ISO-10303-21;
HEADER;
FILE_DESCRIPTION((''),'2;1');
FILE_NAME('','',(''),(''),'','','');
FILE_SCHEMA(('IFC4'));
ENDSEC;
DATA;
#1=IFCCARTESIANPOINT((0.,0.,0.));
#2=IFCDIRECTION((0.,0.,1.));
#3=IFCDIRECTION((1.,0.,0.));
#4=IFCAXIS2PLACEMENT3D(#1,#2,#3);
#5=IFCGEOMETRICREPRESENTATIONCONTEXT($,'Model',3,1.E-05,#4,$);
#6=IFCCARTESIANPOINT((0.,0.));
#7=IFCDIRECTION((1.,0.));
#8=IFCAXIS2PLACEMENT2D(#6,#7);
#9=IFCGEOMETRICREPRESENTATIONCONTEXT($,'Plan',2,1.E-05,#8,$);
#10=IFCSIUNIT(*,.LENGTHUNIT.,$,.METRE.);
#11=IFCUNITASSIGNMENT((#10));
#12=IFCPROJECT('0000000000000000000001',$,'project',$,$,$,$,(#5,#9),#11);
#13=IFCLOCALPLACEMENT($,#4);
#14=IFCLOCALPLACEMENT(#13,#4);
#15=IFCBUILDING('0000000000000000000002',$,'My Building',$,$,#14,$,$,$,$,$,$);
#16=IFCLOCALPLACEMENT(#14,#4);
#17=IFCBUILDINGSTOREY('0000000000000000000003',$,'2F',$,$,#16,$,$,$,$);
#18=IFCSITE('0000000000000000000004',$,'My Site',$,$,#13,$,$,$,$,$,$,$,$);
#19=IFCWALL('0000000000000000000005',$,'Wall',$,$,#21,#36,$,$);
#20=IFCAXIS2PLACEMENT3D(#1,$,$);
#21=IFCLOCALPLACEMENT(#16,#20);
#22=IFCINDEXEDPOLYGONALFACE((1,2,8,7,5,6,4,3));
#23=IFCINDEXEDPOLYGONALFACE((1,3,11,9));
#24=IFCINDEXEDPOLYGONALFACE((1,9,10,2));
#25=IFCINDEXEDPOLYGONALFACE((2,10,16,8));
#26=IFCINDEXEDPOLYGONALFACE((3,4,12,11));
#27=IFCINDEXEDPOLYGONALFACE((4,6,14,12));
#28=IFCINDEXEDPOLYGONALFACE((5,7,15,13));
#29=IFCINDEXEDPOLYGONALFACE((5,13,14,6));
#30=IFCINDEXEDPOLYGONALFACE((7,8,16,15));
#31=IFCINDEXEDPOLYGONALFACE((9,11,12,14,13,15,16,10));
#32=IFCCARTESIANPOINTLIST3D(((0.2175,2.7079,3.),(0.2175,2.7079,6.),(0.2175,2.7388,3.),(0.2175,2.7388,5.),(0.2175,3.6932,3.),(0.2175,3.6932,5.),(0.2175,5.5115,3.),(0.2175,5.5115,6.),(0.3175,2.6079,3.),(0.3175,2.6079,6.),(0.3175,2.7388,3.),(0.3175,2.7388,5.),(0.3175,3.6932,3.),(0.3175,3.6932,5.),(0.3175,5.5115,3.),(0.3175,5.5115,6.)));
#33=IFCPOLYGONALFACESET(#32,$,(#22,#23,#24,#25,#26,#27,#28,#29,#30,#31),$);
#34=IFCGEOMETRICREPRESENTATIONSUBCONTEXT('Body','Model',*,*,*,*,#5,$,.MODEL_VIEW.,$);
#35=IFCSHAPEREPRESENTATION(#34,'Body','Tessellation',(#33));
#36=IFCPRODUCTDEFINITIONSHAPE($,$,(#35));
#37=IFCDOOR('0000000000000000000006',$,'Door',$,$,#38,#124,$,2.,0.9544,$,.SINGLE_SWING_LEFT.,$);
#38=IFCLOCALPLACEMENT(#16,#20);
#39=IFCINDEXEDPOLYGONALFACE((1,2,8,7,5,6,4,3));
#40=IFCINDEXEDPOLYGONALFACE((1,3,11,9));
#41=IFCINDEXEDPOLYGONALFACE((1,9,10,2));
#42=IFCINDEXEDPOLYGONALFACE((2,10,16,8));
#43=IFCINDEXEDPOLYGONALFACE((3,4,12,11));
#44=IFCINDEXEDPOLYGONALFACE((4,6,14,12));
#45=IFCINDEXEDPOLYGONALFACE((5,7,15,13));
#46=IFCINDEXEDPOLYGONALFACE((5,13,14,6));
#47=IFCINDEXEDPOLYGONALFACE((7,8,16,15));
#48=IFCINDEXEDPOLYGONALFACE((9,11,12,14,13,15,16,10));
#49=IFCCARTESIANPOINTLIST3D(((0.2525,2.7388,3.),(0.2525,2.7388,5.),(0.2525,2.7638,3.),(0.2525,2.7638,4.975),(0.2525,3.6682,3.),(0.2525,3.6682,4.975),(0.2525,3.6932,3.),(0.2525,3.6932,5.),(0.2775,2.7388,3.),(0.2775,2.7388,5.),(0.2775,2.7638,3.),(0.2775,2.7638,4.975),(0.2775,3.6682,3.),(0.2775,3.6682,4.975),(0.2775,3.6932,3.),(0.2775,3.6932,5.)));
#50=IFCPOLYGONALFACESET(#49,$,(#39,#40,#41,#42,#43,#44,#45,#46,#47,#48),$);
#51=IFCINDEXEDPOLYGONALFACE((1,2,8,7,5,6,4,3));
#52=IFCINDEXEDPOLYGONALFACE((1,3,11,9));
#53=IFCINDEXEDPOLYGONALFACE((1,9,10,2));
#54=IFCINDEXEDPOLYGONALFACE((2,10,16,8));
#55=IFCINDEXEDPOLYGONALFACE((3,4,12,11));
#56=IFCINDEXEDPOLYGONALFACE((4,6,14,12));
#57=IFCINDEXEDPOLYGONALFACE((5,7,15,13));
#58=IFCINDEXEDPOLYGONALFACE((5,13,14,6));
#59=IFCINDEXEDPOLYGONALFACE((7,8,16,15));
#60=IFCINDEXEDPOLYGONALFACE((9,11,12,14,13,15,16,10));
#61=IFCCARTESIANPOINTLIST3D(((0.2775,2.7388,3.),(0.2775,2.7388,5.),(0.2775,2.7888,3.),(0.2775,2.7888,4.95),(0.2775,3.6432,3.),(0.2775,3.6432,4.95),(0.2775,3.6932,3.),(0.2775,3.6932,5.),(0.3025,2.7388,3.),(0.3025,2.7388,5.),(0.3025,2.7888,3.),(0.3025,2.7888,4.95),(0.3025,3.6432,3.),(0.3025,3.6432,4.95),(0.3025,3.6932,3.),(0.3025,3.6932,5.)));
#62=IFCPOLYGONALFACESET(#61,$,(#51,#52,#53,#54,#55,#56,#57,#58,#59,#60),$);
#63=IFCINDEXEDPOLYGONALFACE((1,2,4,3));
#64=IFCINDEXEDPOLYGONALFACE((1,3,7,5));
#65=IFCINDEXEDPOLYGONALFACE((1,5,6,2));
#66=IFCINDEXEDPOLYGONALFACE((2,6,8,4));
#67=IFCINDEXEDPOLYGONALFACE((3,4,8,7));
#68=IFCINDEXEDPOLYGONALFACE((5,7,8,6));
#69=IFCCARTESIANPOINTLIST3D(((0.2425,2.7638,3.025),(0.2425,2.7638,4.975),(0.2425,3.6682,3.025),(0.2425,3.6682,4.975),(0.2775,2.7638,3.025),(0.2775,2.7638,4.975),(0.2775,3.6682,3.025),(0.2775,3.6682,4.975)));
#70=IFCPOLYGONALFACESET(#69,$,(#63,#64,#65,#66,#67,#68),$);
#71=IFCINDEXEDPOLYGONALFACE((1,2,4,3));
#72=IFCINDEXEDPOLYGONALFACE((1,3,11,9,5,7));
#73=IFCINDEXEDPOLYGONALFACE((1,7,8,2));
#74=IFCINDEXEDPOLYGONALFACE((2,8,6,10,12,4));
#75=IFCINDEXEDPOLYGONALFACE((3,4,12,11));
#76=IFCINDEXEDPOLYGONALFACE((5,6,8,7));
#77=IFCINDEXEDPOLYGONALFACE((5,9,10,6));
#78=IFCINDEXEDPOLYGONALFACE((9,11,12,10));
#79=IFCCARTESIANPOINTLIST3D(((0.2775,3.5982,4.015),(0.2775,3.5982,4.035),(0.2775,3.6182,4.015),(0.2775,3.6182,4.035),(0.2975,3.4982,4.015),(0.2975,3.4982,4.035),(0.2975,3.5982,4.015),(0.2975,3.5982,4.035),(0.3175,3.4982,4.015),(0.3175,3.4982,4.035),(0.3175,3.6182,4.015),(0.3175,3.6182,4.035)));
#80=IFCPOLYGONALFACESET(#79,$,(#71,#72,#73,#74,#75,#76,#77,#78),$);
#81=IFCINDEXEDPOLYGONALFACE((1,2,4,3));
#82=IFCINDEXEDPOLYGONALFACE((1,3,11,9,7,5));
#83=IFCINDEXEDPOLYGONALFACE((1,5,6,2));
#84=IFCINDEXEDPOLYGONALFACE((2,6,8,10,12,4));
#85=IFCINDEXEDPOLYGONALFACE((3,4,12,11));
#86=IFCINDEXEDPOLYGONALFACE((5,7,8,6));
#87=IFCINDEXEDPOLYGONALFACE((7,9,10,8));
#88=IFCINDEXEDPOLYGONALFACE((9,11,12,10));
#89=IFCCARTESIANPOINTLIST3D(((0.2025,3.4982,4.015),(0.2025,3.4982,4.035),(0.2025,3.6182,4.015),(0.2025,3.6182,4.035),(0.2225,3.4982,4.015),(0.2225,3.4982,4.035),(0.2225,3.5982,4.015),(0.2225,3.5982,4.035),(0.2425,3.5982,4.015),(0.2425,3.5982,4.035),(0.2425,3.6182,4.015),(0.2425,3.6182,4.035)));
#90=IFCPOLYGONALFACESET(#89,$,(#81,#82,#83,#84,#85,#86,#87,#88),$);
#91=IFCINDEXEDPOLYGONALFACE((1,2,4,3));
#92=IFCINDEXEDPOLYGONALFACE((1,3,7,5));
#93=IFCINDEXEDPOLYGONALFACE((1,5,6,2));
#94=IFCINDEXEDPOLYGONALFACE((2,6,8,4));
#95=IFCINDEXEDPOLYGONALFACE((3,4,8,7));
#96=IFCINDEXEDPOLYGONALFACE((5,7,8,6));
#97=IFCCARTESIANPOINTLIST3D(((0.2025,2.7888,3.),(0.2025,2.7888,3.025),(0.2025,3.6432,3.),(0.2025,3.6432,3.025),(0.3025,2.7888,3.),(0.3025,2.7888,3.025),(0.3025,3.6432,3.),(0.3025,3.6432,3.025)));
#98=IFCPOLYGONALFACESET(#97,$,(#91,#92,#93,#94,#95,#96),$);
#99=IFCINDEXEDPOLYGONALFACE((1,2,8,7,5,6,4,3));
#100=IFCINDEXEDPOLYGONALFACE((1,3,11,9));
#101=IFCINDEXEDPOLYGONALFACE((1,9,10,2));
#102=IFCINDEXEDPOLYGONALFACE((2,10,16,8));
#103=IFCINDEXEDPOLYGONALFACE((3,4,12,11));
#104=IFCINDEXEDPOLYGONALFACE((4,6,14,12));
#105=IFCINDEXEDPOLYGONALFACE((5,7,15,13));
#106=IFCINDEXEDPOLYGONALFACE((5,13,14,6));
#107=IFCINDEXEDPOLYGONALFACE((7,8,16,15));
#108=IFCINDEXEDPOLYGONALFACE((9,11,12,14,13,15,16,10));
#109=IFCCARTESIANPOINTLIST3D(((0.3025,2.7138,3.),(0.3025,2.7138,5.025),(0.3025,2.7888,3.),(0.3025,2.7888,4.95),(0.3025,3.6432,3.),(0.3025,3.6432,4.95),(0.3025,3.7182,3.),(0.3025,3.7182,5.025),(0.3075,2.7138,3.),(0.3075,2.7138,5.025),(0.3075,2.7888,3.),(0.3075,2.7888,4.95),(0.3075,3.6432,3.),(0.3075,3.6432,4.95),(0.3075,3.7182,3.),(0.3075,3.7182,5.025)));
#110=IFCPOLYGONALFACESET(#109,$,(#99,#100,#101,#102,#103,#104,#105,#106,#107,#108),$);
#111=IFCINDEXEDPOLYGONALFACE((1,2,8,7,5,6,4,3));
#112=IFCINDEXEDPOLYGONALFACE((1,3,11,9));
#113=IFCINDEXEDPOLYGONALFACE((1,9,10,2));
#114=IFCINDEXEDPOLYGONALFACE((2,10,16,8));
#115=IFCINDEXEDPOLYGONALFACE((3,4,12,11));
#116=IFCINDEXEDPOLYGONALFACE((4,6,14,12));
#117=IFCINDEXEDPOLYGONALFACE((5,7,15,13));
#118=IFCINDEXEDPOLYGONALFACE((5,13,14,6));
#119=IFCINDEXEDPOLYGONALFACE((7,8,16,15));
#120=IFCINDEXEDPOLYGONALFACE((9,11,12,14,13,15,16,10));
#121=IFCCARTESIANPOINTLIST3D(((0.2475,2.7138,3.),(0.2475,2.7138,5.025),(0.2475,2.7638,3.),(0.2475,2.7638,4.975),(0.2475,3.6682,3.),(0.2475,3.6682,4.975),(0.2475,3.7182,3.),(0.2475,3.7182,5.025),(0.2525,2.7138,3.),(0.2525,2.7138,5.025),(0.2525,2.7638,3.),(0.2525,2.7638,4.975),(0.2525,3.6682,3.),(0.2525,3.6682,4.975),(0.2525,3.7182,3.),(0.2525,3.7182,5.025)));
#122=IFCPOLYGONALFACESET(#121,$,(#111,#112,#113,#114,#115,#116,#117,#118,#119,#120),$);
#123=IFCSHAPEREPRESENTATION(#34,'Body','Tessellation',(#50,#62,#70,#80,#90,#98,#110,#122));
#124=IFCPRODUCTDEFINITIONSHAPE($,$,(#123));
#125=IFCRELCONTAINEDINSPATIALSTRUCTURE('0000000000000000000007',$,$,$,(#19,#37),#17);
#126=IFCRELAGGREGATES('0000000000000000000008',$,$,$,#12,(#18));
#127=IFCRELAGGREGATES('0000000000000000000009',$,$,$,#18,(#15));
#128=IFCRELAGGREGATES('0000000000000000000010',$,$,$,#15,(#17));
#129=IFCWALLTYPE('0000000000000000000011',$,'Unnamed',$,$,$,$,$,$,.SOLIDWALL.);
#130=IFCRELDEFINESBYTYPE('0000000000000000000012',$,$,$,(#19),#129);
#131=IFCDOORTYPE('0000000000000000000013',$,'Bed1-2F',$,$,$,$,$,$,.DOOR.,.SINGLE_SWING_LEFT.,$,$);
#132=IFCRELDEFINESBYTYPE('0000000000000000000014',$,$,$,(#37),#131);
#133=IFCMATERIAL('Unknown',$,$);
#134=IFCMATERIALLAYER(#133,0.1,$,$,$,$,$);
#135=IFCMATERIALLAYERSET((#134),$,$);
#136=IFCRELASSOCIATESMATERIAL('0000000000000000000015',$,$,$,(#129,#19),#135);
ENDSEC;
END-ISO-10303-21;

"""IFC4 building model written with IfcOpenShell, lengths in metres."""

from ifc_helpers import new_model, entity, si_unit, frame, origin_with_axes, origin_2d_with_axis, place, context, subcontext, project, spatial, line, indexed_curve, outline, extrude, shape, source, transform, mapped, material, layer, layer_set, layer_usage, type_object, type_shapes, element, fill, save


model = new_model("IFC4")

# Units and contexts
model_context = context("Model", 3, precision=1e-05, world=origin_with_axes())
plan_context = context("Plan", 2, precision=1e-05, world=origin_2d_with_axis())
body_context_1 = subcontext(model_context, "Body", "Model", "MODEL_VIEW")
body_context_2 = subcontext(plan_context, "Body", "Plan", "PLAN_VIEW")
ifc_project = project(units=[si_unit("LENGTHUNIT", "METRE")], contexts=[model_context, plan_context])

# Site, building, storey
site_placement = place(None, origin_with_axes())
site = spatial("IfcSite", under=ifc_project, at=site_placement, Name="My Site")
building_placement = place(site_placement, origin_with_axes())
building = spatial("IfcBuilding", under=site, at=building_placement, Name="My Building")
storey_placement = place(building_placement, origin_with_axes())
storey = spatial("IfcBuildingStorey", under=building, at=storey_placement, Name="2F")

# Shared definitions
ifc_material = material(Name="Unknown")

# Shared definitions
ifc_layer = layer(ifc_material, 0.1)
ifc_layer_set = layer_set([ifc_layer])
wall_type = type_object("IfcWallType", Name="Unnamed", PredefinedType="SOLIDWALL", material=ifc_layer_set)

# Wall, opening, door
ifc_layer_usage_1 = layer_usage(ifc_layer_set, "AXIS2", "POSITIVE", 0.0)
wall_1_placement = place(storey_placement, frame((0.3175, 2.7079, 3.0), z_axis=(0.0, 0.0, 1.0), x_axis=(0.0, 1.0, 0.0)))
wall_1 = element("IfcWall", 1, at=wall_1_placement, inside=storey, type_object=wall_type, material=ifc_layer_usage_1, Name="Wall", context=body_context_1, shape_type="SweptSolid", body=[
    extrude(outline(indexed_curve([(-0.1, 0.0), (0.0, 0.1), (2.8037, 0.1), (2.8037, 0.0)], segments=[line(1, 2, 3, 4, 1)])), origin_with_axes(), (0.0, 0.0, 1.0), 3.0),
])
shared_shape_1 = source(origin_with_axes(), body_context_1, "Body", "SweptSolid", [
    extrude(outline(indexed_curve([(0.0, 0.0), (0.9544, 0.0), (0.9544, 2.0), (0.0, 2.0)], segments=[line(1, 2, 3, 4, 1)])), frame((0.0, -0.6, 0.0), z_axis=(0.0, -1.0, 0.0), x_axis=(1.0, 0.0, 0.0)), (0.0, 0.0, -1.0), 1.2),
])
opening_1_placement = place(wall_1_placement, frame((0.0309, 0.015, 0.0), z_axis=(0.0, 0.0, 1.0), x_axis=(1.0, 0.0, 0.0)))
opening_1 = element("IfcOpeningElement", 2, at=opening_1_placement, cuts=wall_1, PredefinedType="OPENING", context=body_context_1, shape_type="MappedRepresentation", body=[
    mapped(shared_shape_1, transform((0.0, 0.0, 0.0), x_axis=(1.0, 0.0, 0.0), y_axis=(0.0, 1.0, 0.0), z_axis=(0.0, 0.0, 1.0), scale=1.0)),
])
door_type_1 = type_object("IfcDoorType", Name="Bed1-2F", OperationType="SINGLE_SWING_LEFT", PredefinedType="DOOR")
shared_shape_2 = source(origin_with_axes(), body_context_1, "Body", "SweptSolid", [
    extrude(outline(indexed_curve([(0.0, 0.0), (0.0, 2.0), (0.9544, 2.0), (0.9544, 0.0), (0.9294, 0.0), (0.9294, 1.975), (0.025, 1.975), (0.025, 0.0)], segments=[line(1, 2, 3, 4, 5, 6, 7, 8, 1)])), frame((0.0, 0.025, 0.0), z_axis=(0.0, -1.0, 0.0), x_axis=(1.0, 0.0, 0.0)), (0.0, 0.0, -1.0), 0.025),
    extrude(outline(indexed_curve([(0.0, 0.0), (0.0, 2.0), (0.9544, 2.0), (0.9544, 0.0), (0.9044, 0.0), (0.9044, 1.95), (0.05, 1.95), (0.05, 0.0)], segments=[line(1, 2, 3, 4, 5, 6, 7, 8, 1)])), frame((0.0, 0.0, 0.0), z_axis=(0.0, -1.0, 0.0), x_axis=(1.0, 0.0, 0.0)), (0.0, 0.0, -1.0), 0.025),
    extrude(outline(indexed_curve([(0.0, 0.0), (0.9044, 0.0), (0.9044, 0.035), (0.0, 0.035)], segments=[line(1, 2, 3, 4, 1)])), frame((0.025, 0.025, 0.025), z_axis=(0.0, 0.0, 1.0), x_axis=(1.0, 0.0, 0.0)), (0.0, 0.0, 1.0), 1.95),
    extrude(outline(indexed_curve([(0.0, 0.0), (0.0, -0.04), (-0.12, -0.04), (-0.12, -0.02), (-0.02, -0.02), (-0.02, 0.0)], segments=[line(1, 2, 3, 4, 5, 6, 1)])), frame((0.8794, 0.025, 1.015), z_axis=(0.0, 0.0, 1.0), x_axis=(1.0, 0.0, 0.0)), (0.0, 0.0, 1.0), 0.02),
    extrude(outline(indexed_curve([(0.0, 0.0), (0.0, 0.04), (-0.12, 0.04), (-0.12, 0.02), (-0.02, 0.02), (-0.02, 0.0)], segments=[line(1, 2, 3, 4, 5, 6, 1)])), frame((0.8794, 0.06, 1.015), z_axis=(0.0, 0.0, 1.0), x_axis=(1.0, 0.0, 0.0)), (0.0, 0.0, 1.0), 0.02),
    extrude(outline(indexed_curve([(0.0, 0.0), (0.8544, 0.0), (0.8544, 0.1), (0.0, 0.1)], segments=[line(1, 2, 3, 4, 1)])), frame((0.05, 0.0, 0.0), z_axis=(0.0, 0.0, 1.0), x_axis=(1.0, 0.0, 0.0)), (0.0, 0.0, 1.0), 0.025),
    extrude(outline(indexed_curve([(0.0, 0.0), (0.0, 2.025), (1.0044, 2.025), (1.0044, 0.0), (0.9294, 0.0), (0.9294, 1.95), (0.075, 1.95), (0.075, 0.0)], segments=[line(1, 2, 3, 4, 5, 6, 7, 8, 1)])), frame((-0.025, -0.005, 0.0), z_axis=(0.0, -1.0, 0.0), x_axis=(1.0, 0.0, 0.0)), (0.0, 0.0, -1.0), 0.005),
    extrude(outline(indexed_curve([(0.0, 0.0), (0.0, 2.025), (1.0044, 2.025), (1.0044, 0.0), (0.9544, 0.0), (0.9544, 1.975), (0.05, 1.975), (0.05, 0.0)], segments=[line(1, 2, 3, 4, 5, 6, 7, 8, 1)])), frame((-0.025, 0.05, 0.0), z_axis=(0.0, -1.0, 0.0), x_axis=(1.0, 0.0, 0.0)), (0.0, 0.0, -1.0), 0.005),
])
shared_shape_3 = source(origin_with_axes(), body_context_2, "Body", "Curve2D", [
    entity("IfcIndexedPolyCurve", entity("IfcCartesianPointList2D", [[0.0, 0.0], [0.0, 0.05], [0.025, 0.05], [0.025, 0.025], [0.05, 0.025], [0.05, 0.0]]), [entity("IfcLineIndex", [1, 2, 3, 4, 5, 6, 1])]),
    entity("IfcIndexedPolyCurve", entity("IfcCartesianPointList2D", [[0.9544, 0.0], [0.9544, 0.05], [0.9294, 0.05], [0.9294, 0.025], [0.9044, 0.025], [0.9044, 0.0]]), [entity("IfcLineIndex", [1, 2, 3, 4, 5, 6, 1])]),
    entity("IfcTrimmedCurve", entity("IfcEllipse", entity("IfcAxis2Placement2D", entity("IfcCartesianPoint", [0.06, 0.05]), entity("IfcDirection", [1.0, 0.0])), 0.8694, 0.9044), [entity("IfcCartesianPoint", [0.9294, 0.05])], [entity("IfcCartesianPoint", [0.06, 0.9544])], True, "CARTESIAN"),
    entity("IfcIndexedPolyCurve", entity("IfcCartesianPointList2D", [[0.025, 0.05], [0.06, 0.05], [0.06, 0.9544], [0.025, 0.9544]]), [entity("IfcLineIndex", [1, 2, 3, 4, 1])]),
])
type_shapes(door_type_1, [shared_shape_2, shared_shape_3])
door_1_placement = place(opening_1_placement, frame((0.0, 0.0, 0.0), z_axis=(0.0, 0.0, 1.0), x_axis=(1.0, 0.0, 0.0)))
door_1 = element("IfcDoor", 3, at=door_1_placement, inside=storey, type_object=door_type_1, Name="Door", OperationType="SINGLE_SWING_LEFT", OverallHeight=2.0, OverallWidth=0.9544, shapes=[
    shape(body_context_1, "Body", "MappedRepresentation", [mapped(shared_shape_2, transform((0.0, 0.0, 0.0), x_axis=(1.0, 0.0, 0.0), y_axis=(0.0, 1.0, 0.0), z_axis=(0.0, 0.0, 1.0), scale=1.0))]),
    shape(body_context_2, "Body", "MappedRepresentation", [mapped(shared_shape_3, transform((0.0, 0.0, 0.0), x_axis=(1.0, 0.0, 0.0), y_axis=(0.0, 1.0, 0.0), z_axis=(0.0, 0.0, 1.0), scale=1.0))]),
])
fill(opening_1, door_1)

save(model, "model.ifc")
